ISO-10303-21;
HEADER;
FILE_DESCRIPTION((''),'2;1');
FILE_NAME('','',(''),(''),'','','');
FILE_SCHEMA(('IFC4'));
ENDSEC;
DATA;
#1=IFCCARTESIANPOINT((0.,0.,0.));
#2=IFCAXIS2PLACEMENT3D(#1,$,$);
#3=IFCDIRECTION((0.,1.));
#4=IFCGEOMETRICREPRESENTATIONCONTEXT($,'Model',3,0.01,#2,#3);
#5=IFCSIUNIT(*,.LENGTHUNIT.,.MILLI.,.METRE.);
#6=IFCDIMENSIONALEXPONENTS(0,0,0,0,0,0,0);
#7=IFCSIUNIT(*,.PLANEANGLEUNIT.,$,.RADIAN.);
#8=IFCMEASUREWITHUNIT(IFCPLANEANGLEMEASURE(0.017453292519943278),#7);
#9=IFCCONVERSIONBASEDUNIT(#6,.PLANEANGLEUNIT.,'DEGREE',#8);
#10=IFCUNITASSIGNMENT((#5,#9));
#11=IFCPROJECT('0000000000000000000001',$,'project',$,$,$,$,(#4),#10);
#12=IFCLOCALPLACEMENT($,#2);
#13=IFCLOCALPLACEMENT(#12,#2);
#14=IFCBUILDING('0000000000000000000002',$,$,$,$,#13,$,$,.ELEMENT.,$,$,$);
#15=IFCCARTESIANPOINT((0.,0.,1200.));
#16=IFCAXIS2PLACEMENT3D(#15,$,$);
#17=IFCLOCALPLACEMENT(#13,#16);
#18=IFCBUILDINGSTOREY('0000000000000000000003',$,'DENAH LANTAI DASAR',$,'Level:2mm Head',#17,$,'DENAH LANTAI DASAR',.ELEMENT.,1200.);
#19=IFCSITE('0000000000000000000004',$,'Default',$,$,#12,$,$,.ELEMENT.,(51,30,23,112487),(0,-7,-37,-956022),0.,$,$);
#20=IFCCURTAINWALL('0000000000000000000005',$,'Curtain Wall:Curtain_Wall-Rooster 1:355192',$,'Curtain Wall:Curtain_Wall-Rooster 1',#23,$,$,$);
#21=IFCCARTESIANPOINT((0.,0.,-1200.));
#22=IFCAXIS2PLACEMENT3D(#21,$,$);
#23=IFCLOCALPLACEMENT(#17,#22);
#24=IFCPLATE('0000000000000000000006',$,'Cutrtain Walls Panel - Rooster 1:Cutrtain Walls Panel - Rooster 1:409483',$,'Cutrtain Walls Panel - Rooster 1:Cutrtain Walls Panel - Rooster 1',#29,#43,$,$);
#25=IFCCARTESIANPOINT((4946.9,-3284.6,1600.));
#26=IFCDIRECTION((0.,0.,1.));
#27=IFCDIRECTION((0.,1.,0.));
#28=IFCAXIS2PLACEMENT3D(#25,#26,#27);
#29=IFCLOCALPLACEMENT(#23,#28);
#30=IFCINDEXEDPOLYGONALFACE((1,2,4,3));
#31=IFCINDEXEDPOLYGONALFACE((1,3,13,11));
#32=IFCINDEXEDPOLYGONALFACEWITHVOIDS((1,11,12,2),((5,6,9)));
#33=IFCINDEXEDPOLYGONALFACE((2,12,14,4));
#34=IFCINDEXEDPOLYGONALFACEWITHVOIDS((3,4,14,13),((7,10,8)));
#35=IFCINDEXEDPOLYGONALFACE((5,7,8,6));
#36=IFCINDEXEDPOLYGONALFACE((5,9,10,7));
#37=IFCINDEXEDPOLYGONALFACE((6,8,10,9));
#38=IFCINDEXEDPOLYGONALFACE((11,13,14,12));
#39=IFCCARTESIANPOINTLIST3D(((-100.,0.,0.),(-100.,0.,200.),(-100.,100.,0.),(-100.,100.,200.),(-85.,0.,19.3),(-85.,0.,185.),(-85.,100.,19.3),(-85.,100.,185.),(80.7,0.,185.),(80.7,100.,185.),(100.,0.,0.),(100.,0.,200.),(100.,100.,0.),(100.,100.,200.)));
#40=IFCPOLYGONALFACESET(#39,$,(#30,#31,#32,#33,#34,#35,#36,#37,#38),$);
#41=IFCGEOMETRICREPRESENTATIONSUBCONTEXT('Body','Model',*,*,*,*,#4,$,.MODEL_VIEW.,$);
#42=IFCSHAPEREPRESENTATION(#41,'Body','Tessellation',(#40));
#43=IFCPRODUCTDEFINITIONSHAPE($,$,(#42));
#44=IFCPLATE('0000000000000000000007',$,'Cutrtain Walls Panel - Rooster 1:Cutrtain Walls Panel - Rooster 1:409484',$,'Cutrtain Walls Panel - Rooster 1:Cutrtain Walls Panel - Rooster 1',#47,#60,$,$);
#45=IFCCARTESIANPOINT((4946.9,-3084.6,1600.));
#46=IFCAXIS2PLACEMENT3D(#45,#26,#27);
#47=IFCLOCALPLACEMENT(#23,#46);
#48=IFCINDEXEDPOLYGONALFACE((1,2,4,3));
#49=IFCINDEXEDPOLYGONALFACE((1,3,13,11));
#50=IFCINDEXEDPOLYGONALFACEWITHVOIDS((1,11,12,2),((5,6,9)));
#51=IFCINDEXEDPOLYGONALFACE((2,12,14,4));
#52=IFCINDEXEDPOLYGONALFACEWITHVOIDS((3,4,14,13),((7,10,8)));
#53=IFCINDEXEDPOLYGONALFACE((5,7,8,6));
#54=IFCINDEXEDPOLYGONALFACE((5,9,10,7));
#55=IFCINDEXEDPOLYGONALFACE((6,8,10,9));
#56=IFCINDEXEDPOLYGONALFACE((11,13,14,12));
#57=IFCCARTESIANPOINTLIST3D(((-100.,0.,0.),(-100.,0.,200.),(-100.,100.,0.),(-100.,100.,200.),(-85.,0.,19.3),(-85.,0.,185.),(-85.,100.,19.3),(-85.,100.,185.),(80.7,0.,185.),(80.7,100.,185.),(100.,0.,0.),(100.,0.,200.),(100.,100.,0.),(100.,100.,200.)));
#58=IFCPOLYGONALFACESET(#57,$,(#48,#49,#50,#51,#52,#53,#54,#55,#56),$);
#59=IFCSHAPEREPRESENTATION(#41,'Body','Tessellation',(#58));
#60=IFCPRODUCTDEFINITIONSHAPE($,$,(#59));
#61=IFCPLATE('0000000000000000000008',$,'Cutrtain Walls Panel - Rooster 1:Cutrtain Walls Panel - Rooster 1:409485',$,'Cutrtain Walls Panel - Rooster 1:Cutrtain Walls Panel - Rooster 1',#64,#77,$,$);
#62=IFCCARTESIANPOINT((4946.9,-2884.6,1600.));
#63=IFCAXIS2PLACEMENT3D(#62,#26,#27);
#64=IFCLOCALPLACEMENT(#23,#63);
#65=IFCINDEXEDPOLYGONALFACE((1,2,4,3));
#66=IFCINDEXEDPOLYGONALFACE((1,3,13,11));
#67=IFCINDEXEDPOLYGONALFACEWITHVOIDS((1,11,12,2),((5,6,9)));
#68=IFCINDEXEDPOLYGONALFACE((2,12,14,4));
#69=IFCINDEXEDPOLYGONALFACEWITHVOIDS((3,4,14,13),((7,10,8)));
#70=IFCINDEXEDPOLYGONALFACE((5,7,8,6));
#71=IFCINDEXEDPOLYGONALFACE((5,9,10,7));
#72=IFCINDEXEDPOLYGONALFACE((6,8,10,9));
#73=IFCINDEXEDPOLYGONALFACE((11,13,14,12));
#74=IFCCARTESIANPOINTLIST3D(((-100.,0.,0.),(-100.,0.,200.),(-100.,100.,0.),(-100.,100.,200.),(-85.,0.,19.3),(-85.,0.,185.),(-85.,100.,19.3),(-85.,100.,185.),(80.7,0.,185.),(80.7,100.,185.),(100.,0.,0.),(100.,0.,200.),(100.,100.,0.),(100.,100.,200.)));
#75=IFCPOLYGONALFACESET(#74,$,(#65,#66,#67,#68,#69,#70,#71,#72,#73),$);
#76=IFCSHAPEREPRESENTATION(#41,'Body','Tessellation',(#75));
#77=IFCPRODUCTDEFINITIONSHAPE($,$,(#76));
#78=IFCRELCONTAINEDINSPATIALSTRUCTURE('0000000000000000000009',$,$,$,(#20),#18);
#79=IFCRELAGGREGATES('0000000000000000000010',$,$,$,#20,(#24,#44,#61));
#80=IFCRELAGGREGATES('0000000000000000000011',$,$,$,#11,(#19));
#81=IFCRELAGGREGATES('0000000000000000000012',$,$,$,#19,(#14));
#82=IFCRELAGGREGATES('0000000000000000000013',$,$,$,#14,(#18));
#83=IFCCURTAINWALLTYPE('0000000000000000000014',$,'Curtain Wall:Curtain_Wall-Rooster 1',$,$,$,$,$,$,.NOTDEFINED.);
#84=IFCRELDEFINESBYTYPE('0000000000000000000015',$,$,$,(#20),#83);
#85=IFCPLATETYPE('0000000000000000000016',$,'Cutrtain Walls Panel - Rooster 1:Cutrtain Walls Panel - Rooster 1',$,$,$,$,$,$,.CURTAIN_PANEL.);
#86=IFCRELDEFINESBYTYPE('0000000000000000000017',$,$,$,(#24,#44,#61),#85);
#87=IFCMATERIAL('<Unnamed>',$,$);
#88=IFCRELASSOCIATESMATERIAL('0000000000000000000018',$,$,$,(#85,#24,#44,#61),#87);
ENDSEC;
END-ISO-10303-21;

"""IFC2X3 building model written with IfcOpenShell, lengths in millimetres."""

from ifc_helpers import new_model, entity, si_unit, converted_unit, direction, frame, origin, place, context, subcontext, project, spatial, polyline, outline, extrude, source, transform, mapped, material, type_object, type_shapes, element, aggregate, save


model = new_model("IFC2X3")

# Units and contexts
model_context = context("Model", 3, precision=0.01, world=origin(), true_north=direction((0.0, 1.0)))
body_context = subcontext(model_context, "Body", "Model", "MODEL_VIEW")
ifc_project = project(units=[si_unit("LENGTHUNIT", "METRE", prefix="MILLI"), converted_unit("PLANEANGLEUNIT", "DEGREE", entity("IfcPlaneAngleMeasure", 0.017453292519943278), si_unit("PLANEANGLEUNIT", "RADIAN"), dimensions=[0, 0, 0, 0, 0, 0, 0])], contexts=[model_context])

# Site, building, storey
site_placement = place(None, origin())
site = spatial("IfcSite", under=ifc_project, at=site_placement, Name="Default", CompositionType="ELEMENT", RefLatitude=(51, 30, 23, 112487), RefLongitude=(0, -7, -37, -956022), RefElevation=0.0)
building_placement = place(site_placement, origin())
building = spatial("IfcBuilding", under=site, at=building_placement, CompositionType="ELEMENT")
storey_placement = place(building_placement, frame((0.0, 0.0, 1200.0)))
storey = spatial("IfcBuildingStorey", under=building, at=storey_placement, Name="DENAH LANTAI DASAR", ObjectType="Level:2mm Head", LongName="DENAH LANTAI DASAR", CompositionType="ELEMENT", Elevation=1200.0)

# Curtain wall, plates
curtain_wall_type = type_object("IfcCurtainWallType", Name="Curtain Wall:Curtain_Wall-Rooster 1", PredefinedType="NOTDEFINED")
ifc_material_1 = material(Name="<Unnamed>")
plate_type = type_object("IfcPlateType", Name="Cutrtain Walls Panel - Rooster 1:Cutrtain Walls Panel - Rooster 1", PredefinedType="CURTAIN_PANEL", material=ifc_material_1)
shared_shape = source(origin(), body_context, "Body", "SweptSolid", [
    extrude(outline(polyline([(-100.0, -100.0), (100.0, -100.0), (100.0, 100.0), (-100.0, 100.0), (-100.0, -100.0)]), holes=[polyline([(80.7, 85.0), (-85.0, -80.7), (-85.0, 85.0), (80.7, 85.0)])]), frame((0.0, 0.0, 100.0), z_axis=(0.0, 1.0, 0.0), x_axis=(0.0, 0.0, -1.0)), (0.0, 0.0, 1.0), 100.0),
])
type_shapes(plate_type, [shared_shape])
curtain_wall_1_placement = place(storey_placement, frame((0.0, 0.0, -1200.0)))
curtain_wall_1 = element("IfcCurtainWall", 1, at=curtain_wall_1_placement, inside=storey, type_object=curtain_wall_type, Name="Curtain Wall:Curtain_Wall-Rooster 1:355192", ObjectType="Curtain Wall:Curtain_Wall-Rooster 1")
plate_1_placement = place(curtain_wall_1_placement, frame((4946.9, -3284.6, 1600.0), z_axis=(0.0, 0.0, 1.0), x_axis=(0.0, 1.0, 0.0)))
plate_1 = element("IfcPlate", 2, at=plate_1_placement, type_object=plate_type, material=ifc_material_1, Name="Cutrtain Walls Panel - Rooster 1:Cutrtain Walls Panel - Rooster 1:409483", ObjectType="Cutrtain Walls Panel - Rooster 1:Cutrtain Walls Panel - Rooster 1", context=body_context, shape_type="MappedRepresentation", body=[
    mapped(shared_shape, transform((0.0, 0.0, 0.0), scale=1.0)),
])
plate_2_placement = place(curtain_wall_1_placement, frame((4946.9, -3084.6, 1600.0), z_axis=(0.0, 0.0, 1.0), x_axis=(0.0, 1.0, 0.0)))
plate_2 = element("IfcPlate", 3, at=plate_2_placement, type_object=plate_type, material=ifc_material_1, Name="Cutrtain Walls Panel - Rooster 1:Cutrtain Walls Panel - Rooster 1:409484", ObjectType="Cutrtain Walls Panel - Rooster 1:Cutrtain Walls Panel - Rooster 1", context=body_context, shape_type="MappedRepresentation", body=[
    mapped(shared_shape, transform((0.0, 0.0, 0.0), scale=1.0)),
])
plate_3_placement = place(curtain_wall_1_placement, frame((4946.9, -2884.6, 1600.0), z_axis=(0.0, 0.0, 1.0), x_axis=(0.0, 1.0, 0.0)))
plate_3 = element("IfcPlate", 4, at=plate_3_placement, type_object=plate_type, material=ifc_material_1, Name="Cutrtain Walls Panel - Rooster 1:Cutrtain Walls Panel - Rooster 1:409485", ObjectType="Cutrtain Walls Panel - Rooster 1:Cutrtain Walls Panel - Rooster 1", context=body_context, shape_type="MappedRepresentation", body=[
    mapped(shared_shape, transform((0.0, 0.0, 0.0), scale=1.0)),
])
aggregate(curtain_wall_1, [plate_1, plate_2, plate_3])

save(model, "model.ifc")
